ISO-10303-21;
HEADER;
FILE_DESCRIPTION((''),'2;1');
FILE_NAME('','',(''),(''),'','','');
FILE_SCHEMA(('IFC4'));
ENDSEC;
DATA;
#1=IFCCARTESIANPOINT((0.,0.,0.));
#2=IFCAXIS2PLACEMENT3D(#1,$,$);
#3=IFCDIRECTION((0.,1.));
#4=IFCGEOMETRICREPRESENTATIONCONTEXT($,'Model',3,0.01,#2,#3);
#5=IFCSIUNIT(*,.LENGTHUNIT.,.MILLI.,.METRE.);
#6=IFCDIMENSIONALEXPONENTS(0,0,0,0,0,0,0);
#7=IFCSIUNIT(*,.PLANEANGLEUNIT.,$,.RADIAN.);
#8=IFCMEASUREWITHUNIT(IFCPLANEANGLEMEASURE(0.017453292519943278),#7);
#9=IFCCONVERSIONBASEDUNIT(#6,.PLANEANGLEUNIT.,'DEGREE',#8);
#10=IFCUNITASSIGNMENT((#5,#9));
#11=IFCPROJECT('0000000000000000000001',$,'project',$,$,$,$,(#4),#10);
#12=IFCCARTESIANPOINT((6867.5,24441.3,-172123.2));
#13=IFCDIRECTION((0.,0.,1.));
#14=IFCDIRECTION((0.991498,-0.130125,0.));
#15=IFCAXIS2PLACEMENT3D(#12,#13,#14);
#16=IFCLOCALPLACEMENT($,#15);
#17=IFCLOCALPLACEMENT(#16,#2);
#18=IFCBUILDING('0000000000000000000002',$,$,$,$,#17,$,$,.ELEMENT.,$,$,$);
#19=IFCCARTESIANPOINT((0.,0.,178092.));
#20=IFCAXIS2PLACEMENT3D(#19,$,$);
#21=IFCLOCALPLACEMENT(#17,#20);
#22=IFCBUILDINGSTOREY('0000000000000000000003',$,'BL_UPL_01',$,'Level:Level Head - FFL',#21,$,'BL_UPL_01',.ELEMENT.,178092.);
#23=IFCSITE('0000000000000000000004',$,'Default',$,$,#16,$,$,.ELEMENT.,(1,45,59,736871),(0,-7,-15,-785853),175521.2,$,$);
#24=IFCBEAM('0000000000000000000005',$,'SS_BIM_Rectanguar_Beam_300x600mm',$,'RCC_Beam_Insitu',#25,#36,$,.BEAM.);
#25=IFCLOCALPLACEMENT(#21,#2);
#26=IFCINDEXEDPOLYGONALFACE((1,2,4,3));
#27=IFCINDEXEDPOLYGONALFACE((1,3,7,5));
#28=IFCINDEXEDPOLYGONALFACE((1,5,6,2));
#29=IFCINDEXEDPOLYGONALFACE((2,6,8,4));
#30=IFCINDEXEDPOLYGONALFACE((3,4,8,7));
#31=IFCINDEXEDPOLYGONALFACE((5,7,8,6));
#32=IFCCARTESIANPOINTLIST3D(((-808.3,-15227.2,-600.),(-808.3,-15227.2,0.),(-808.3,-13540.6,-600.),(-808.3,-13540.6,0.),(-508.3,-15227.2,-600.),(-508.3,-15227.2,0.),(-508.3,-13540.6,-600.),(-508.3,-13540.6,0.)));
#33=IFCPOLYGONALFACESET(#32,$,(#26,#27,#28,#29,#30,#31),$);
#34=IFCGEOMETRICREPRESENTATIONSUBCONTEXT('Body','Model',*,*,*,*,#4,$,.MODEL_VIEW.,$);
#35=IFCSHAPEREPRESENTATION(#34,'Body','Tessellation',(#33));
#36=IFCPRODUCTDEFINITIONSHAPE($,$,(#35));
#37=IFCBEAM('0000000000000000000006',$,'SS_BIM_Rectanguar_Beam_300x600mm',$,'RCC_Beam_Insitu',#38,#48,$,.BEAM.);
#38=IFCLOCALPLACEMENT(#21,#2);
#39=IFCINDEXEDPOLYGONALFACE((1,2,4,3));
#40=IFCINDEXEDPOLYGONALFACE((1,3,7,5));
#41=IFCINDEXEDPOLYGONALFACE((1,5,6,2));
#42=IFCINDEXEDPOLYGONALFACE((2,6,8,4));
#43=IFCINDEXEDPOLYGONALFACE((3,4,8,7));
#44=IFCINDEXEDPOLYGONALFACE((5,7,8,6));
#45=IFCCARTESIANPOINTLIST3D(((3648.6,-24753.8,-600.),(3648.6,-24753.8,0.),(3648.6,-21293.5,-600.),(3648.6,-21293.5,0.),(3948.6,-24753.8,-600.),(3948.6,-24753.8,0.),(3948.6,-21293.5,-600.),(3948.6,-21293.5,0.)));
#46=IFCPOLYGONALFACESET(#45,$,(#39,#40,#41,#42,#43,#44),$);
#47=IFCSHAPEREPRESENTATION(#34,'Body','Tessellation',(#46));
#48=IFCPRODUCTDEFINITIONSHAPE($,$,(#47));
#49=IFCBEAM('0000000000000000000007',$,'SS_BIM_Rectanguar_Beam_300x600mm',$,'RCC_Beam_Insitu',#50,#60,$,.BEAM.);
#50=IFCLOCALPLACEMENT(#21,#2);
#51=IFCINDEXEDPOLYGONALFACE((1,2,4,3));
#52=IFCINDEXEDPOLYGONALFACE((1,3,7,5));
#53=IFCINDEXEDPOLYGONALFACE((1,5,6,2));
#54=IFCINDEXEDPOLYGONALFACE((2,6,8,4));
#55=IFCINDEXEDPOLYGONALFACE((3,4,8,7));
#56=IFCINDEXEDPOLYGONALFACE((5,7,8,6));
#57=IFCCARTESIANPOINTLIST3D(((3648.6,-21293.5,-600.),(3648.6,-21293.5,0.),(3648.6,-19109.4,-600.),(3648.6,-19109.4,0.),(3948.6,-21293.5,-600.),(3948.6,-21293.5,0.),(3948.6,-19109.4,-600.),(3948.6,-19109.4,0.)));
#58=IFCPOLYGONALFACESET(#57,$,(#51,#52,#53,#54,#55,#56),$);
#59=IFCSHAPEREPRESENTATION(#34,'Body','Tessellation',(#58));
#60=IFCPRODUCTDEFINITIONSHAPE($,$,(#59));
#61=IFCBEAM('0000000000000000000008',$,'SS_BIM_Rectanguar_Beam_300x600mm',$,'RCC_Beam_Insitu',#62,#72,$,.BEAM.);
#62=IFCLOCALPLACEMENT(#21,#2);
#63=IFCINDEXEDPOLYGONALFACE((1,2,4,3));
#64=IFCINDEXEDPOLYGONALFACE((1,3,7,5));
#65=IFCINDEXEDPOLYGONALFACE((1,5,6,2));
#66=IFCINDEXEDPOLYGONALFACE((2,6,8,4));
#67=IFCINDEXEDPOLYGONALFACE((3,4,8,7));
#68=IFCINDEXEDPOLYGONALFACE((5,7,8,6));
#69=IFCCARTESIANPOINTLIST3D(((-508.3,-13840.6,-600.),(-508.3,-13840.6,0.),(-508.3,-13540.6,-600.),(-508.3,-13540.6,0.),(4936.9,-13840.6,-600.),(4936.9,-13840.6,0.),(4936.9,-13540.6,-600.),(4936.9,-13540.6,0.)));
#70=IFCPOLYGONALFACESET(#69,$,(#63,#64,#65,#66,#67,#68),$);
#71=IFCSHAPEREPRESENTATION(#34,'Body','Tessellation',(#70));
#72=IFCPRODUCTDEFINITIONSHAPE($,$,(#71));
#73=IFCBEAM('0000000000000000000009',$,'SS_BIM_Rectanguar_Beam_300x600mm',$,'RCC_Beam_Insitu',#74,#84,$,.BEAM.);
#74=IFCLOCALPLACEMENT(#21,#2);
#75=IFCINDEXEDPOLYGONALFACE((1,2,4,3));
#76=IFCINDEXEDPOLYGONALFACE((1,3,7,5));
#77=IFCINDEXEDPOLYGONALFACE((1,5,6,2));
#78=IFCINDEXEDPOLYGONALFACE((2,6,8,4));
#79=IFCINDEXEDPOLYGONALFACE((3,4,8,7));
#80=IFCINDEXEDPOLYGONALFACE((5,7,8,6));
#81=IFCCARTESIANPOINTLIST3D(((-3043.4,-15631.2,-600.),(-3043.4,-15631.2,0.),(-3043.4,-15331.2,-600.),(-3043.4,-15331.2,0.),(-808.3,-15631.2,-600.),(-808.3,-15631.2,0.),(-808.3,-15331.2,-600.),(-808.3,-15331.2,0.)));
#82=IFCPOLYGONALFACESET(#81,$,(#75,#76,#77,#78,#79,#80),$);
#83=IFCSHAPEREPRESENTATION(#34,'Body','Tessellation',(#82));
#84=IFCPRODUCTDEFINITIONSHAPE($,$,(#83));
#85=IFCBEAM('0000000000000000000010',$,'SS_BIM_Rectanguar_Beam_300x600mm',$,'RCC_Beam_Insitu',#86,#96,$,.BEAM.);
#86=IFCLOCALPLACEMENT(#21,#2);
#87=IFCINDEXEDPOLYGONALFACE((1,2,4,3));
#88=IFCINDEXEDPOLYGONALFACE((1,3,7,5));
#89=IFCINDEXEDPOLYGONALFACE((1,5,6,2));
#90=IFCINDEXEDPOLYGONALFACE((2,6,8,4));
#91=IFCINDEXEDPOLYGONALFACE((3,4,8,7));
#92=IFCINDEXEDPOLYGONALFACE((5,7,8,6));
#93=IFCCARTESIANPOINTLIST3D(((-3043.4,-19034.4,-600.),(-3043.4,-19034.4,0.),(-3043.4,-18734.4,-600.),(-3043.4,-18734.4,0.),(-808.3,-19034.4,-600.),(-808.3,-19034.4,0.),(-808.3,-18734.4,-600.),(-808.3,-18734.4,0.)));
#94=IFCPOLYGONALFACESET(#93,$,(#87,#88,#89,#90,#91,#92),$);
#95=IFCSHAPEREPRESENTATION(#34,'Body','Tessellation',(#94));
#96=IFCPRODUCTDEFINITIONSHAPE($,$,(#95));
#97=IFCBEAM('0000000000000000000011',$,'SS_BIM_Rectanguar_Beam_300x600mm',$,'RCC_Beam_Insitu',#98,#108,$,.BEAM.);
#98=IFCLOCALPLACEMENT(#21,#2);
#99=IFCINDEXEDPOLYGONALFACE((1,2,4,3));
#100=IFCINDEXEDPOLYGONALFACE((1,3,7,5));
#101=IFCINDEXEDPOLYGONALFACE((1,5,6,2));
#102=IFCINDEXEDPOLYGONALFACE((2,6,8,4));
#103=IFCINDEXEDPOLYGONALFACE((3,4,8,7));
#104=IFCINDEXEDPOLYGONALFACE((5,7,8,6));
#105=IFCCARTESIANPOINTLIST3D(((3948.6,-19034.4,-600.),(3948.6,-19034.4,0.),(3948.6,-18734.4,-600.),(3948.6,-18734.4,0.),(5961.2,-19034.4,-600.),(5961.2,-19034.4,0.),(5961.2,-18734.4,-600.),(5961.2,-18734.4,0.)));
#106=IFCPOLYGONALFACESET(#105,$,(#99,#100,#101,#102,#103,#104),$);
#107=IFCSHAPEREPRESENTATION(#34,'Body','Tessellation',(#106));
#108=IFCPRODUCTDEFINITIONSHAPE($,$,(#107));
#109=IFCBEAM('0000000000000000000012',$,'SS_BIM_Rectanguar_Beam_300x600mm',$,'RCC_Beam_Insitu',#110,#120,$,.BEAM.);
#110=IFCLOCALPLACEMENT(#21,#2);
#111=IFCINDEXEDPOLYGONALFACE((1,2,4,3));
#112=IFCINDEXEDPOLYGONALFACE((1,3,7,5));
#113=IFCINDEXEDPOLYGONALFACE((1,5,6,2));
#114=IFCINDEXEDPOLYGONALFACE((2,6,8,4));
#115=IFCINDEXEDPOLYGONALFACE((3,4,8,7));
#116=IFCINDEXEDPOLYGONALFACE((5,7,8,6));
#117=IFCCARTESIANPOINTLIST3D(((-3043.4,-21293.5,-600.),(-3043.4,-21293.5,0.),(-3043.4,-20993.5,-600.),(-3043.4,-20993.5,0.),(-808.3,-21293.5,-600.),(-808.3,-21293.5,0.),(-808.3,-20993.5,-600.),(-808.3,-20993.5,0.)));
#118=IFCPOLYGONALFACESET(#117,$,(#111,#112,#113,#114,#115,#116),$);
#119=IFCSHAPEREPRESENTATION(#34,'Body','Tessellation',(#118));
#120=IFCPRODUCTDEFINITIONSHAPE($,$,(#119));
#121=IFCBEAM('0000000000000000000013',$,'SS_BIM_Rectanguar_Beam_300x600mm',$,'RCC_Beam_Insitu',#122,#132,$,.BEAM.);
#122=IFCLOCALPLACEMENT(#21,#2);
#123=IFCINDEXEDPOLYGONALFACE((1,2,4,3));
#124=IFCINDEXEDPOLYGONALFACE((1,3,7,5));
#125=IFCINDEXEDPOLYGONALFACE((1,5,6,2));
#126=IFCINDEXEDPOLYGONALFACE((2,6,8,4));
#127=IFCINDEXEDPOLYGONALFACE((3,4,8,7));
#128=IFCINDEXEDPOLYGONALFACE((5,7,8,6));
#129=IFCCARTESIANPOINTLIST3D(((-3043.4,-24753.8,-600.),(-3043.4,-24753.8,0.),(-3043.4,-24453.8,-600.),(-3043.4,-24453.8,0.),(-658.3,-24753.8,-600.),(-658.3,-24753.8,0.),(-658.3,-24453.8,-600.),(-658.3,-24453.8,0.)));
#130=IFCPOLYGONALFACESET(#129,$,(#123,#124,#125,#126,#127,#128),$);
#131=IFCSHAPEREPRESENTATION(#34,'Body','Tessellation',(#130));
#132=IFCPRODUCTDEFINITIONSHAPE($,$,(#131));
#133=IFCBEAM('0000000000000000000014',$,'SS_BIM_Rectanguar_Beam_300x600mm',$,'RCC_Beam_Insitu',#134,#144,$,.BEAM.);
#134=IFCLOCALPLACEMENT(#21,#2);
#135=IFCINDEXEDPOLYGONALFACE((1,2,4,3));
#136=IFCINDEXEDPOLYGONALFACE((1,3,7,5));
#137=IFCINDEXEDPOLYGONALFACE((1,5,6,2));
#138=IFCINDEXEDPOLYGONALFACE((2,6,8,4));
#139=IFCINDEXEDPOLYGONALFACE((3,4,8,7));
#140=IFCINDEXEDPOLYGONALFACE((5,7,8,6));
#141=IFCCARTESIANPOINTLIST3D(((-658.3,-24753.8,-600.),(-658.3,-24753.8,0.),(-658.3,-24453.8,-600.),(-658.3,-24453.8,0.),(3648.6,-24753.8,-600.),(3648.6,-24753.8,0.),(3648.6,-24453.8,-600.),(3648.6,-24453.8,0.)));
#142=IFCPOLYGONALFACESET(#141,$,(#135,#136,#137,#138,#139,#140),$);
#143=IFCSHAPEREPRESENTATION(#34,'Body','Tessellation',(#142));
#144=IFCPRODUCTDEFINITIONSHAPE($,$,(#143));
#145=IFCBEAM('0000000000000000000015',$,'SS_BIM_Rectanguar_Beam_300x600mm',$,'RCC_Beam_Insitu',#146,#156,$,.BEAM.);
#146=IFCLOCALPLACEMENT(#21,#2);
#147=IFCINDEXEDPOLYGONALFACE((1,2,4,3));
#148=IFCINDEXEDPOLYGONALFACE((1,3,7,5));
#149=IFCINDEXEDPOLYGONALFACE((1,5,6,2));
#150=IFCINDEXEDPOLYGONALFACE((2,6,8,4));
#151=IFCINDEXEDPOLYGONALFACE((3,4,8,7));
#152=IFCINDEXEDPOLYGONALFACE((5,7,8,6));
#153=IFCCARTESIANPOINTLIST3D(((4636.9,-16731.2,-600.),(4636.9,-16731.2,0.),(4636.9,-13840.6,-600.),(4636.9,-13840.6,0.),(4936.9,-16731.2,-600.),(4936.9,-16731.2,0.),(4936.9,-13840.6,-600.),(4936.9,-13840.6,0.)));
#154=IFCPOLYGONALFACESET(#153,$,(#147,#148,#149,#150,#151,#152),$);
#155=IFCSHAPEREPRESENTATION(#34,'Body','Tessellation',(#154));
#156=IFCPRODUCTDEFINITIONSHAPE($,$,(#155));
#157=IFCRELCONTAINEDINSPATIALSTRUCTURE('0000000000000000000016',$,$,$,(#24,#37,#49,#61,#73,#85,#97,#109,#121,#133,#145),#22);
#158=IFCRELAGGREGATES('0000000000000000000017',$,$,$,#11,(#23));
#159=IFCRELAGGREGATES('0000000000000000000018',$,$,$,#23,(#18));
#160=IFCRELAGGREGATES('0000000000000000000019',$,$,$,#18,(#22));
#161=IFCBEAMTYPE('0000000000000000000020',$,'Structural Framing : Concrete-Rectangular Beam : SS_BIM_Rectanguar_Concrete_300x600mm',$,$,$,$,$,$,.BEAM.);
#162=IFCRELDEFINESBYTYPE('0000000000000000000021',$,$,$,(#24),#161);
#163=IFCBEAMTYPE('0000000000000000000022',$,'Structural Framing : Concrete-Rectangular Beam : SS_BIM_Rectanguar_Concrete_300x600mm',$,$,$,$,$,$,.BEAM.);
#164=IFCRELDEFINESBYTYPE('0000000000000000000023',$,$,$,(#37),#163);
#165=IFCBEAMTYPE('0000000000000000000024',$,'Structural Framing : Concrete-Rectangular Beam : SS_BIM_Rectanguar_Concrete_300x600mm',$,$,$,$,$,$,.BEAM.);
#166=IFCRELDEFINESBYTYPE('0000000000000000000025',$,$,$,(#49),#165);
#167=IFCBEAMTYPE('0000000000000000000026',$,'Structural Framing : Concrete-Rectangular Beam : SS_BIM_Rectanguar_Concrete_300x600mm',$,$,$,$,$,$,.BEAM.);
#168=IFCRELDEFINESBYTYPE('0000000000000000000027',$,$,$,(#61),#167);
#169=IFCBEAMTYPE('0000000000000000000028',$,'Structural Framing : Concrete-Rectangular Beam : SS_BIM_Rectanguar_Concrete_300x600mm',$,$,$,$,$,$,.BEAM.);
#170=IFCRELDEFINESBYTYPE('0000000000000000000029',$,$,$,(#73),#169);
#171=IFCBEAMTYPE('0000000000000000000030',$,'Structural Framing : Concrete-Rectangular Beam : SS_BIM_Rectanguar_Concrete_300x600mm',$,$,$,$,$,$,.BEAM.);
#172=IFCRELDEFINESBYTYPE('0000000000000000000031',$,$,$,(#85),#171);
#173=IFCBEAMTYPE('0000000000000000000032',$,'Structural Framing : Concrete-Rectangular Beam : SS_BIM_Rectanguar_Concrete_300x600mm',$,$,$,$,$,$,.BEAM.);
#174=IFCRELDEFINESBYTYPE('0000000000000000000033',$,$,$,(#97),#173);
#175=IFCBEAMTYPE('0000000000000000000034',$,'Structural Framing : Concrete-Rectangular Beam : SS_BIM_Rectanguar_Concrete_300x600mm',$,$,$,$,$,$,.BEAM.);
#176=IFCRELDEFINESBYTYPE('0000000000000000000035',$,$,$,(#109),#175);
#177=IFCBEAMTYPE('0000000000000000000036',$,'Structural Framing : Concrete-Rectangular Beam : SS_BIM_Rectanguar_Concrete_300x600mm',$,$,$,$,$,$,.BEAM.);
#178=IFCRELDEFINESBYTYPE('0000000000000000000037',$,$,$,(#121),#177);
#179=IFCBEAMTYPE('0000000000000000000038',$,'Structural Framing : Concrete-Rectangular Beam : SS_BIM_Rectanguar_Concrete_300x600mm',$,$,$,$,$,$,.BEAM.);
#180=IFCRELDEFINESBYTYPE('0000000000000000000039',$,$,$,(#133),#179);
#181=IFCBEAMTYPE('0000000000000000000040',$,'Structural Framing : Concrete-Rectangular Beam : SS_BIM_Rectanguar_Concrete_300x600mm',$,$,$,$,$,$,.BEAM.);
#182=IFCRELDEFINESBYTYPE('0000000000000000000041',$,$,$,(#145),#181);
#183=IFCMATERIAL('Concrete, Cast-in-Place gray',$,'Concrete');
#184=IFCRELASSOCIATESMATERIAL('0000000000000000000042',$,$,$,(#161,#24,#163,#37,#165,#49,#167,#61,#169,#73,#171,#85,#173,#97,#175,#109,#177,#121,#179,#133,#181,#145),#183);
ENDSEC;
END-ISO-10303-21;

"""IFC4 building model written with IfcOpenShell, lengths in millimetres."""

from ifc_helpers import new_model, entity, si_unit, converted_unit, direction, frame, origin, place, context, subcontext, project, spatial, indexed_curve, outline, extrude, source, transform, mapped, material, type_object, type_shapes, element, save


model = new_model("IFC4")

# Units and contexts
model_context = context("Model", 3, precision=0.01, world=origin(), true_north=direction((0.0, 1.0)))
body_context = subcontext(model_context, "Body", "Model", "MODEL_VIEW")
ifc_project = project(units=[si_unit("LENGTHUNIT", "METRE", prefix="MILLI"), converted_unit("PLANEANGLEUNIT", "DEGREE", entity("IfcPlaneAngleMeasure", 0.017453292519943278), si_unit("PLANEANGLEUNIT", "RADIAN"), dimensions=[0, 0, 0, 0, 0, 0, 0])], contexts=[model_context])

# Site, building, storey
site_placement = place(None, frame((6867.5, 24441.3, -172123.2), z_axis=(0.0, 0.0, 1.0), x_axis=(0.991498, -0.130125, 0.0)))
site = spatial("IfcSite", under=ifc_project, at=site_placement, Name="Default", CompositionType="ELEMENT", RefLatitude=(1, 45, 59, 736871), RefLongitude=(0, -7, -15, -785853), RefElevation=175521.2)
building_placement = place(site_placement, origin())
building = spatial("IfcBuilding", under=site, at=building_placement, CompositionType="ELEMENT")
storey_placement = place(building_placement, frame((0.0, 0.0, 178092.0)))
storey = spatial("IfcBuildingStorey", under=building, at=storey_placement, Name="BL_UPL_01", ObjectType="Level:Level Head - FFL", LongName="BL_UPL_01", CompositionType="ELEMENT", Elevation=178092.0)

# Shared definitions
ifc_material_1 = material(Name="Concrete, Cast-in-Place gray", Category="Concrete")

# Beams
beam_type_1 = type_object("IfcBeamType", Name="Structural Framing : Concrete-Rectangular Beam : SS_BIM_Rectanguar_Concrete_300x600mm", PredefinedType="BEAM", material=ifc_material_1)
shared_shape_1 = source(origin(), body_context, "Body", "SweptSolid", [
    extrude(outline(indexed_curve([(-150.0, -300.0), (150.0, -300.0), (150.0, 300.0), (-150.0, 300.0), (-150.0, -300.0)], self_intersect=False)), frame((-658.3, -15227.2, 177792.0), z_axis=(0.0, 1.0, 0.0), x_axis=(-1.0, 0.0, 0.0)), (0.0, 0.0, 1.0), 1686.5),
])
type_shapes(beam_type_1, [shared_shape_1])
beam_1_placement = place(storey_placement, frame((0.0, 0.0, -178092.0)))
element("IfcBeam", 1, at=beam_1_placement, inside=storey, type_object=beam_type_1, material=ifc_material_1, Name="SS_BIM_Rectanguar_Beam_300x600mm", ObjectType="RCC_Beam_Insitu", PredefinedType="BEAM", context=body_context, shape_type="MappedRepresentation", body=[
    mapped(shared_shape_1, transform((0.0, 0.0, 0.0), scale=1.0)),
])
beam_type_2 = type_object("IfcBeamType", Name="Structural Framing : Concrete-Rectangular Beam : SS_BIM_Rectanguar_Concrete_300x600mm", PredefinedType="BEAM", material=ifc_material_1)
shared_shape_2 = source(origin(), body_context, "Body", "SweptSolid", [
    extrude(outline(indexed_curve([(-150.0, -300.0), (150.0, -300.0), (150.0, 300.0), (-150.0, 300.0), (-150.0, -300.0)], self_intersect=False)), frame((3798.6, -24753.8, 177792.0), z_axis=(0.0, 1.0, 0.0), x_axis=(-1.0, 0.0, 0.0)), (0.0, 0.0, 1.0), 3460.3),
])
type_shapes(beam_type_2, [shared_shape_2])
beam_2_placement = place(storey_placement, frame((0.0, 0.0, -178092.0)))
element("IfcBeam", 2, at=beam_2_placement, inside=storey, type_object=beam_type_2, material=ifc_material_1, Name="SS_BIM_Rectanguar_Beam_300x600mm", ObjectType="RCC_Beam_Insitu", PredefinedType="BEAM", context=body_context, shape_type="MappedRepresentation", body=[
    mapped(shared_shape_2, transform((0.0, 0.0, 0.0), scale=1.0)),
])
beam_type_3 = type_object("IfcBeamType", Name="Structural Framing : Concrete-Rectangular Beam : SS_BIM_Rectanguar_Concrete_300x600mm", PredefinedType="BEAM", material=ifc_material_1)
shared_shape_3 = source(origin(), body_context, "Body", "SweptSolid", [
    extrude(outline(indexed_curve([(-150.0, -300.0), (150.0, -300.0), (150.0, 300.0), (-150.0, 300.0), (-150.0, -300.0)], self_intersect=False)), frame((3798.6, -21293.5, 177792.0), z_axis=(0.0, 1.0, 0.0), x_axis=(-1.0, 0.0, 0.0)), (0.0, 0.0, 1.0), 2184.1),
])
type_shapes(beam_type_3, [shared_shape_3])
beam_3_placement = place(storey_placement, frame((0.0, 0.0, -178092.0)))
element("IfcBeam", 3, at=beam_3_placement, inside=storey, type_object=beam_type_3, material=ifc_material_1, Name="SS_BIM_Rectanguar_Beam_300x600mm", ObjectType="RCC_Beam_Insitu", PredefinedType="BEAM", context=body_context, shape_type="MappedRepresentation", body=[
    mapped(shared_shape_3, transform((0.0, 0.0, 0.0), scale=1.0)),
])
beam_type_4 = type_object("IfcBeamType", Name="Structural Framing : Concrete-Rectangular Beam : SS_BIM_Rectanguar_Concrete_300x600mm", PredefinedType="BEAM", material=ifc_material_1)
shared_shape_4 = source(origin(), body_context, "Body", "SweptSolid", [
    extrude(outline(indexed_curve([(-300.0, -150.0), (300.0, -150.0), (300.0, 150.0), (-300.0, 150.0), (-300.0, -150.0)], self_intersect=False)), frame((-508.3, -13690.6, 177792.0), z_axis=(1.0, 0.0, 0.0), x_axis=(0.0, 0.0, -1.0)), (0.0, 0.0, 1.0), 5445.2),
])
type_shapes(beam_type_4, [shared_shape_4])
beam_4_placement = place(storey_placement, frame((0.0, 0.0, -178092.0)))
element("IfcBeam", 4, at=beam_4_placement, inside=storey, type_object=beam_type_4, material=ifc_material_1, Name="SS_BIM_Rectanguar_Beam_300x600mm", ObjectType="RCC_Beam_Insitu", PredefinedType="BEAM", context=body_context, shape_type="MappedRepresentation", body=[
    mapped(shared_shape_4, transform((0.0, 0.0, 0.0), scale=1.0)),
])
beam_type_5 = type_object("IfcBeamType", Name="Structural Framing : Concrete-Rectangular Beam : SS_BIM_Rectanguar_Concrete_300x600mm", PredefinedType="BEAM", material=ifc_material_1)
shared_shape_5 = source(origin(), body_context, "Body", "SweptSolid", [
    extrude(outline(indexed_curve([(-300.0, -150.0), (300.0, -150.0), (300.0, 150.0), (-300.0, 150.0), (-300.0, -150.0)], self_intersect=False)), frame((-3043.4, -15481.2, 177792.0), z_axis=(1.0, 0.0, 0.0), x_axis=(0.0, 0.0, -1.0)), (0.0, 0.0, 1.0), 2235.1),
])
type_shapes(beam_type_5, [shared_shape_5])
beam_5_placement = place(storey_placement, frame((0.0, 0.0, -178092.0)))
element("IfcBeam", 5, at=beam_5_placement, inside=storey, type_object=beam_type_5, material=ifc_material_1, Name="SS_BIM_Rectanguar_Beam_300x600mm", ObjectType="RCC_Beam_Insitu", PredefinedType="BEAM", context=body_context, shape_type="MappedRepresentation", body=[
    mapped(shared_shape_5, transform((0.0, 0.0, 0.0), scale=1.0)),
])
beam_type_6 = type_object("IfcBeamType", Name="Structural Framing : Concrete-Rectangular Beam : SS_BIM_Rectanguar_Concrete_300x600mm", PredefinedType="BEAM", material=ifc_material_1)
shared_shape_6 = source(origin(), body_context, "Body", "SweptSolid", [
    extrude(outline(indexed_curve([(-300.0, -150.0), (300.0, -150.0), (300.0, 150.0), (-300.0, 150.0), (-300.0, -150.0)], self_intersect=False)), frame((-3043.4, -18884.4, 177792.0), z_axis=(1.0, 0.0, 0.0), x_axis=(0.0, 0.0, -1.0)), (0.0, 0.0, 1.0), 2235.1),
])
type_shapes(beam_type_6, [shared_shape_6])
beam_6_placement = place(storey_placement, frame((0.0, 0.0, -178092.0)))
element("IfcBeam", 6, at=beam_6_placement, inside=storey, type_object=beam_type_6, material=ifc_material_1, Name="SS_BIM_Rectanguar_Beam_300x600mm", ObjectType="RCC_Beam_Insitu", PredefinedType="BEAM", context=body_context, shape_type="MappedRepresentation", body=[
    mapped(shared_shape_6, transform((0.0, 0.0, 0.0), scale=1.0)),
])
beam_type_7 = type_object("IfcBeamType", Name="Structural Framing : Concrete-Rectangular Beam : SS_BIM_Rectanguar_Concrete_300x600mm", PredefinedType="BEAM", material=ifc_material_1)
shared_shape_7 = source(origin(), body_context, "Body", "SweptSolid", [
    extrude(outline(indexed_curve([(-300.0, -150.0), (300.0, -150.0), (300.0, 150.0), (-300.0, 150.0), (-300.0, -150.0)], self_intersect=False)), frame((3948.6, -18884.4, 177792.0), z_axis=(1.0, 0.0, 0.0), x_axis=(0.0, 0.0, -1.0)), (0.0, 0.0, 1.0), 2012.6),
])
type_shapes(beam_type_7, [shared_shape_7])
beam_7_placement = place(storey_placement, frame((0.0, 0.0, -178092.0)))
element("IfcBeam", 7, at=beam_7_placement, inside=storey, type_object=beam_type_7, material=ifc_material_1, Name="SS_BIM_Rectanguar_Beam_300x600mm", ObjectType="RCC_Beam_Insitu", PredefinedType="BEAM", context=body_context, shape_type="MappedRepresentation", body=[
    mapped(shared_shape_7, transform((0.0, 0.0, 0.0), scale=1.0)),
])
beam_type_8 = type_object("IfcBeamType", Name="Structural Framing : Concrete-Rectangular Beam : SS_BIM_Rectanguar_Concrete_300x600mm", PredefinedType="BEAM", material=ifc_material_1)
shared_shape_8 = source(origin(), body_context, "Body", "SweptSolid", [
    extrude(outline(indexed_curve([(-300.0, -150.0), (300.0, -150.0), (300.0, 150.0), (-300.0, 150.0), (-300.0, -150.0)], self_intersect=False)), frame((-3043.4, -21143.5, 177792.0), z_axis=(1.0, 0.0, 0.0), x_axis=(0.0, 0.0, -1.0)), (0.0, 0.0, 1.0), 2235.1),
])
type_shapes(beam_type_8, [shared_shape_8])
beam_8_placement = place(storey_placement, frame((0.0, 0.0, -178092.0)))
element("IfcBeam", 8, at=beam_8_placement, inside=storey, type_object=beam_type_8, material=ifc_material_1, Name="SS_BIM_Rectanguar_Beam_300x600mm", ObjectType="RCC_Beam_Insitu", PredefinedType="BEAM", context=body_context, shape_type="MappedRepresentation", body=[
    mapped(shared_shape_8, transform((0.0, 0.0, 0.0), scale=1.0)),
])
beam_type_9 = type_object("IfcBeamType", Name="Structural Framing : Concrete-Rectangular Beam : SS_BIM_Rectanguar_Concrete_300x600mm", PredefinedType="BEAM", material=ifc_material_1)
shared_shape_9 = source(origin(), body_context, "Body", "SweptSolid", [
    extrude(outline(indexed_curve([(-300.0, -150.0), (300.0, -150.0), (300.0, 150.0), (-300.0, 150.0), (-300.0, -150.0)], self_intersect=False)), frame((-3043.4, -24603.8, 177792.0), z_axis=(1.0, 0.0, 0.0), x_axis=(0.0, 0.0, -1.0)), (0.0, 0.0, 1.0), 2385.1),
])
type_shapes(beam_type_9, [shared_shape_9])
beam_9_placement = place(storey_placement, frame((0.0, 0.0, -178092.0)))
element("IfcBeam", 9, at=beam_9_placement, inside=storey, type_object=beam_type_9, material=ifc_material_1, Name="SS_BIM_Rectanguar_Beam_300x600mm", ObjectType="RCC_Beam_Insitu", PredefinedType="BEAM", context=body_context, shape_type="MappedRepresentation", body=[
    mapped(shared_shape_9, transform((0.0, 0.0, 0.0), scale=1.0)),
])
beam_type_10 = type_object("IfcBeamType", Name="Structural Framing : Concrete-Rectangular Beam : SS_BIM_Rectanguar_Concrete_300x600mm", PredefinedType="BEAM", material=ifc_material_1)
shared_shape_10 = source(origin(), body_context, "Body", "SweptSolid", [
    extrude(outline(indexed_curve([(-300.0, -150.0), (300.0, -150.0), (300.0, 150.0), (-300.0, 150.0), (-300.0, -150.0)], self_intersect=False)), frame((-658.3, -24603.8, 177792.0), z_axis=(1.0, 0.0, 0.0), x_axis=(0.0, 0.0, -1.0)), (0.0, 0.0, 1.0), 4306.9),
])
type_shapes(beam_type_10, [shared_shape_10])
beam_10_placement = place(storey_placement, frame((0.0, 0.0, -178092.0)))
element("IfcBeam", 10, at=beam_10_placement, inside=storey, type_object=beam_type_10, material=ifc_material_1, Name="SS_BIM_Rectanguar_Beam_300x600mm", ObjectType="RCC_Beam_Insitu", PredefinedType="BEAM", context=body_context, shape_type="MappedRepresentation", body=[
    mapped(shared_shape_10, transform((0.0, 0.0, 0.0), scale=1.0)),
])
beam_type_11 = type_object("IfcBeamType", Name="Structural Framing : Concrete-Rectangular Beam : SS_BIM_Rectanguar_Concrete_300x600mm", PredefinedType="BEAM", material=ifc_material_1)
shared_shape_11 = source(origin(), body_context, "Body", "SweptSolid", [
    extrude(outline(indexed_curve([(-150.0, -300.0), (150.0, -300.0), (150.0, 300.0), (-150.0, 300.0), (-150.0, -300.0)], self_intersect=False)), frame((4786.9, -13840.6, 177792.0), z_axis=(0.0, -1.0, 0.0), x_axis=(-1.0, 0.0, 0.0)), (0.0, 0.0, 1.0), 2890.6),
])
type_shapes(beam_type_11, [shared_shape_11])
beam_11_placement = place(storey_placement, frame((0.0, 0.0, -178092.0)))
element("IfcBeam", 11, at=beam_11_placement, inside=storey, type_object=beam_type_11, material=ifc_material_1, Name="SS_BIM_Rectanguar_Beam_300x600mm", ObjectType="RCC_Beam_Insitu", PredefinedType="BEAM", context=body_context, shape_type="MappedRepresentation", body=[
    mapped(shared_shape_11, transform((0.0, 0.0, 0.0), scale=1.0)),
])

save(model, "model.ifc")
